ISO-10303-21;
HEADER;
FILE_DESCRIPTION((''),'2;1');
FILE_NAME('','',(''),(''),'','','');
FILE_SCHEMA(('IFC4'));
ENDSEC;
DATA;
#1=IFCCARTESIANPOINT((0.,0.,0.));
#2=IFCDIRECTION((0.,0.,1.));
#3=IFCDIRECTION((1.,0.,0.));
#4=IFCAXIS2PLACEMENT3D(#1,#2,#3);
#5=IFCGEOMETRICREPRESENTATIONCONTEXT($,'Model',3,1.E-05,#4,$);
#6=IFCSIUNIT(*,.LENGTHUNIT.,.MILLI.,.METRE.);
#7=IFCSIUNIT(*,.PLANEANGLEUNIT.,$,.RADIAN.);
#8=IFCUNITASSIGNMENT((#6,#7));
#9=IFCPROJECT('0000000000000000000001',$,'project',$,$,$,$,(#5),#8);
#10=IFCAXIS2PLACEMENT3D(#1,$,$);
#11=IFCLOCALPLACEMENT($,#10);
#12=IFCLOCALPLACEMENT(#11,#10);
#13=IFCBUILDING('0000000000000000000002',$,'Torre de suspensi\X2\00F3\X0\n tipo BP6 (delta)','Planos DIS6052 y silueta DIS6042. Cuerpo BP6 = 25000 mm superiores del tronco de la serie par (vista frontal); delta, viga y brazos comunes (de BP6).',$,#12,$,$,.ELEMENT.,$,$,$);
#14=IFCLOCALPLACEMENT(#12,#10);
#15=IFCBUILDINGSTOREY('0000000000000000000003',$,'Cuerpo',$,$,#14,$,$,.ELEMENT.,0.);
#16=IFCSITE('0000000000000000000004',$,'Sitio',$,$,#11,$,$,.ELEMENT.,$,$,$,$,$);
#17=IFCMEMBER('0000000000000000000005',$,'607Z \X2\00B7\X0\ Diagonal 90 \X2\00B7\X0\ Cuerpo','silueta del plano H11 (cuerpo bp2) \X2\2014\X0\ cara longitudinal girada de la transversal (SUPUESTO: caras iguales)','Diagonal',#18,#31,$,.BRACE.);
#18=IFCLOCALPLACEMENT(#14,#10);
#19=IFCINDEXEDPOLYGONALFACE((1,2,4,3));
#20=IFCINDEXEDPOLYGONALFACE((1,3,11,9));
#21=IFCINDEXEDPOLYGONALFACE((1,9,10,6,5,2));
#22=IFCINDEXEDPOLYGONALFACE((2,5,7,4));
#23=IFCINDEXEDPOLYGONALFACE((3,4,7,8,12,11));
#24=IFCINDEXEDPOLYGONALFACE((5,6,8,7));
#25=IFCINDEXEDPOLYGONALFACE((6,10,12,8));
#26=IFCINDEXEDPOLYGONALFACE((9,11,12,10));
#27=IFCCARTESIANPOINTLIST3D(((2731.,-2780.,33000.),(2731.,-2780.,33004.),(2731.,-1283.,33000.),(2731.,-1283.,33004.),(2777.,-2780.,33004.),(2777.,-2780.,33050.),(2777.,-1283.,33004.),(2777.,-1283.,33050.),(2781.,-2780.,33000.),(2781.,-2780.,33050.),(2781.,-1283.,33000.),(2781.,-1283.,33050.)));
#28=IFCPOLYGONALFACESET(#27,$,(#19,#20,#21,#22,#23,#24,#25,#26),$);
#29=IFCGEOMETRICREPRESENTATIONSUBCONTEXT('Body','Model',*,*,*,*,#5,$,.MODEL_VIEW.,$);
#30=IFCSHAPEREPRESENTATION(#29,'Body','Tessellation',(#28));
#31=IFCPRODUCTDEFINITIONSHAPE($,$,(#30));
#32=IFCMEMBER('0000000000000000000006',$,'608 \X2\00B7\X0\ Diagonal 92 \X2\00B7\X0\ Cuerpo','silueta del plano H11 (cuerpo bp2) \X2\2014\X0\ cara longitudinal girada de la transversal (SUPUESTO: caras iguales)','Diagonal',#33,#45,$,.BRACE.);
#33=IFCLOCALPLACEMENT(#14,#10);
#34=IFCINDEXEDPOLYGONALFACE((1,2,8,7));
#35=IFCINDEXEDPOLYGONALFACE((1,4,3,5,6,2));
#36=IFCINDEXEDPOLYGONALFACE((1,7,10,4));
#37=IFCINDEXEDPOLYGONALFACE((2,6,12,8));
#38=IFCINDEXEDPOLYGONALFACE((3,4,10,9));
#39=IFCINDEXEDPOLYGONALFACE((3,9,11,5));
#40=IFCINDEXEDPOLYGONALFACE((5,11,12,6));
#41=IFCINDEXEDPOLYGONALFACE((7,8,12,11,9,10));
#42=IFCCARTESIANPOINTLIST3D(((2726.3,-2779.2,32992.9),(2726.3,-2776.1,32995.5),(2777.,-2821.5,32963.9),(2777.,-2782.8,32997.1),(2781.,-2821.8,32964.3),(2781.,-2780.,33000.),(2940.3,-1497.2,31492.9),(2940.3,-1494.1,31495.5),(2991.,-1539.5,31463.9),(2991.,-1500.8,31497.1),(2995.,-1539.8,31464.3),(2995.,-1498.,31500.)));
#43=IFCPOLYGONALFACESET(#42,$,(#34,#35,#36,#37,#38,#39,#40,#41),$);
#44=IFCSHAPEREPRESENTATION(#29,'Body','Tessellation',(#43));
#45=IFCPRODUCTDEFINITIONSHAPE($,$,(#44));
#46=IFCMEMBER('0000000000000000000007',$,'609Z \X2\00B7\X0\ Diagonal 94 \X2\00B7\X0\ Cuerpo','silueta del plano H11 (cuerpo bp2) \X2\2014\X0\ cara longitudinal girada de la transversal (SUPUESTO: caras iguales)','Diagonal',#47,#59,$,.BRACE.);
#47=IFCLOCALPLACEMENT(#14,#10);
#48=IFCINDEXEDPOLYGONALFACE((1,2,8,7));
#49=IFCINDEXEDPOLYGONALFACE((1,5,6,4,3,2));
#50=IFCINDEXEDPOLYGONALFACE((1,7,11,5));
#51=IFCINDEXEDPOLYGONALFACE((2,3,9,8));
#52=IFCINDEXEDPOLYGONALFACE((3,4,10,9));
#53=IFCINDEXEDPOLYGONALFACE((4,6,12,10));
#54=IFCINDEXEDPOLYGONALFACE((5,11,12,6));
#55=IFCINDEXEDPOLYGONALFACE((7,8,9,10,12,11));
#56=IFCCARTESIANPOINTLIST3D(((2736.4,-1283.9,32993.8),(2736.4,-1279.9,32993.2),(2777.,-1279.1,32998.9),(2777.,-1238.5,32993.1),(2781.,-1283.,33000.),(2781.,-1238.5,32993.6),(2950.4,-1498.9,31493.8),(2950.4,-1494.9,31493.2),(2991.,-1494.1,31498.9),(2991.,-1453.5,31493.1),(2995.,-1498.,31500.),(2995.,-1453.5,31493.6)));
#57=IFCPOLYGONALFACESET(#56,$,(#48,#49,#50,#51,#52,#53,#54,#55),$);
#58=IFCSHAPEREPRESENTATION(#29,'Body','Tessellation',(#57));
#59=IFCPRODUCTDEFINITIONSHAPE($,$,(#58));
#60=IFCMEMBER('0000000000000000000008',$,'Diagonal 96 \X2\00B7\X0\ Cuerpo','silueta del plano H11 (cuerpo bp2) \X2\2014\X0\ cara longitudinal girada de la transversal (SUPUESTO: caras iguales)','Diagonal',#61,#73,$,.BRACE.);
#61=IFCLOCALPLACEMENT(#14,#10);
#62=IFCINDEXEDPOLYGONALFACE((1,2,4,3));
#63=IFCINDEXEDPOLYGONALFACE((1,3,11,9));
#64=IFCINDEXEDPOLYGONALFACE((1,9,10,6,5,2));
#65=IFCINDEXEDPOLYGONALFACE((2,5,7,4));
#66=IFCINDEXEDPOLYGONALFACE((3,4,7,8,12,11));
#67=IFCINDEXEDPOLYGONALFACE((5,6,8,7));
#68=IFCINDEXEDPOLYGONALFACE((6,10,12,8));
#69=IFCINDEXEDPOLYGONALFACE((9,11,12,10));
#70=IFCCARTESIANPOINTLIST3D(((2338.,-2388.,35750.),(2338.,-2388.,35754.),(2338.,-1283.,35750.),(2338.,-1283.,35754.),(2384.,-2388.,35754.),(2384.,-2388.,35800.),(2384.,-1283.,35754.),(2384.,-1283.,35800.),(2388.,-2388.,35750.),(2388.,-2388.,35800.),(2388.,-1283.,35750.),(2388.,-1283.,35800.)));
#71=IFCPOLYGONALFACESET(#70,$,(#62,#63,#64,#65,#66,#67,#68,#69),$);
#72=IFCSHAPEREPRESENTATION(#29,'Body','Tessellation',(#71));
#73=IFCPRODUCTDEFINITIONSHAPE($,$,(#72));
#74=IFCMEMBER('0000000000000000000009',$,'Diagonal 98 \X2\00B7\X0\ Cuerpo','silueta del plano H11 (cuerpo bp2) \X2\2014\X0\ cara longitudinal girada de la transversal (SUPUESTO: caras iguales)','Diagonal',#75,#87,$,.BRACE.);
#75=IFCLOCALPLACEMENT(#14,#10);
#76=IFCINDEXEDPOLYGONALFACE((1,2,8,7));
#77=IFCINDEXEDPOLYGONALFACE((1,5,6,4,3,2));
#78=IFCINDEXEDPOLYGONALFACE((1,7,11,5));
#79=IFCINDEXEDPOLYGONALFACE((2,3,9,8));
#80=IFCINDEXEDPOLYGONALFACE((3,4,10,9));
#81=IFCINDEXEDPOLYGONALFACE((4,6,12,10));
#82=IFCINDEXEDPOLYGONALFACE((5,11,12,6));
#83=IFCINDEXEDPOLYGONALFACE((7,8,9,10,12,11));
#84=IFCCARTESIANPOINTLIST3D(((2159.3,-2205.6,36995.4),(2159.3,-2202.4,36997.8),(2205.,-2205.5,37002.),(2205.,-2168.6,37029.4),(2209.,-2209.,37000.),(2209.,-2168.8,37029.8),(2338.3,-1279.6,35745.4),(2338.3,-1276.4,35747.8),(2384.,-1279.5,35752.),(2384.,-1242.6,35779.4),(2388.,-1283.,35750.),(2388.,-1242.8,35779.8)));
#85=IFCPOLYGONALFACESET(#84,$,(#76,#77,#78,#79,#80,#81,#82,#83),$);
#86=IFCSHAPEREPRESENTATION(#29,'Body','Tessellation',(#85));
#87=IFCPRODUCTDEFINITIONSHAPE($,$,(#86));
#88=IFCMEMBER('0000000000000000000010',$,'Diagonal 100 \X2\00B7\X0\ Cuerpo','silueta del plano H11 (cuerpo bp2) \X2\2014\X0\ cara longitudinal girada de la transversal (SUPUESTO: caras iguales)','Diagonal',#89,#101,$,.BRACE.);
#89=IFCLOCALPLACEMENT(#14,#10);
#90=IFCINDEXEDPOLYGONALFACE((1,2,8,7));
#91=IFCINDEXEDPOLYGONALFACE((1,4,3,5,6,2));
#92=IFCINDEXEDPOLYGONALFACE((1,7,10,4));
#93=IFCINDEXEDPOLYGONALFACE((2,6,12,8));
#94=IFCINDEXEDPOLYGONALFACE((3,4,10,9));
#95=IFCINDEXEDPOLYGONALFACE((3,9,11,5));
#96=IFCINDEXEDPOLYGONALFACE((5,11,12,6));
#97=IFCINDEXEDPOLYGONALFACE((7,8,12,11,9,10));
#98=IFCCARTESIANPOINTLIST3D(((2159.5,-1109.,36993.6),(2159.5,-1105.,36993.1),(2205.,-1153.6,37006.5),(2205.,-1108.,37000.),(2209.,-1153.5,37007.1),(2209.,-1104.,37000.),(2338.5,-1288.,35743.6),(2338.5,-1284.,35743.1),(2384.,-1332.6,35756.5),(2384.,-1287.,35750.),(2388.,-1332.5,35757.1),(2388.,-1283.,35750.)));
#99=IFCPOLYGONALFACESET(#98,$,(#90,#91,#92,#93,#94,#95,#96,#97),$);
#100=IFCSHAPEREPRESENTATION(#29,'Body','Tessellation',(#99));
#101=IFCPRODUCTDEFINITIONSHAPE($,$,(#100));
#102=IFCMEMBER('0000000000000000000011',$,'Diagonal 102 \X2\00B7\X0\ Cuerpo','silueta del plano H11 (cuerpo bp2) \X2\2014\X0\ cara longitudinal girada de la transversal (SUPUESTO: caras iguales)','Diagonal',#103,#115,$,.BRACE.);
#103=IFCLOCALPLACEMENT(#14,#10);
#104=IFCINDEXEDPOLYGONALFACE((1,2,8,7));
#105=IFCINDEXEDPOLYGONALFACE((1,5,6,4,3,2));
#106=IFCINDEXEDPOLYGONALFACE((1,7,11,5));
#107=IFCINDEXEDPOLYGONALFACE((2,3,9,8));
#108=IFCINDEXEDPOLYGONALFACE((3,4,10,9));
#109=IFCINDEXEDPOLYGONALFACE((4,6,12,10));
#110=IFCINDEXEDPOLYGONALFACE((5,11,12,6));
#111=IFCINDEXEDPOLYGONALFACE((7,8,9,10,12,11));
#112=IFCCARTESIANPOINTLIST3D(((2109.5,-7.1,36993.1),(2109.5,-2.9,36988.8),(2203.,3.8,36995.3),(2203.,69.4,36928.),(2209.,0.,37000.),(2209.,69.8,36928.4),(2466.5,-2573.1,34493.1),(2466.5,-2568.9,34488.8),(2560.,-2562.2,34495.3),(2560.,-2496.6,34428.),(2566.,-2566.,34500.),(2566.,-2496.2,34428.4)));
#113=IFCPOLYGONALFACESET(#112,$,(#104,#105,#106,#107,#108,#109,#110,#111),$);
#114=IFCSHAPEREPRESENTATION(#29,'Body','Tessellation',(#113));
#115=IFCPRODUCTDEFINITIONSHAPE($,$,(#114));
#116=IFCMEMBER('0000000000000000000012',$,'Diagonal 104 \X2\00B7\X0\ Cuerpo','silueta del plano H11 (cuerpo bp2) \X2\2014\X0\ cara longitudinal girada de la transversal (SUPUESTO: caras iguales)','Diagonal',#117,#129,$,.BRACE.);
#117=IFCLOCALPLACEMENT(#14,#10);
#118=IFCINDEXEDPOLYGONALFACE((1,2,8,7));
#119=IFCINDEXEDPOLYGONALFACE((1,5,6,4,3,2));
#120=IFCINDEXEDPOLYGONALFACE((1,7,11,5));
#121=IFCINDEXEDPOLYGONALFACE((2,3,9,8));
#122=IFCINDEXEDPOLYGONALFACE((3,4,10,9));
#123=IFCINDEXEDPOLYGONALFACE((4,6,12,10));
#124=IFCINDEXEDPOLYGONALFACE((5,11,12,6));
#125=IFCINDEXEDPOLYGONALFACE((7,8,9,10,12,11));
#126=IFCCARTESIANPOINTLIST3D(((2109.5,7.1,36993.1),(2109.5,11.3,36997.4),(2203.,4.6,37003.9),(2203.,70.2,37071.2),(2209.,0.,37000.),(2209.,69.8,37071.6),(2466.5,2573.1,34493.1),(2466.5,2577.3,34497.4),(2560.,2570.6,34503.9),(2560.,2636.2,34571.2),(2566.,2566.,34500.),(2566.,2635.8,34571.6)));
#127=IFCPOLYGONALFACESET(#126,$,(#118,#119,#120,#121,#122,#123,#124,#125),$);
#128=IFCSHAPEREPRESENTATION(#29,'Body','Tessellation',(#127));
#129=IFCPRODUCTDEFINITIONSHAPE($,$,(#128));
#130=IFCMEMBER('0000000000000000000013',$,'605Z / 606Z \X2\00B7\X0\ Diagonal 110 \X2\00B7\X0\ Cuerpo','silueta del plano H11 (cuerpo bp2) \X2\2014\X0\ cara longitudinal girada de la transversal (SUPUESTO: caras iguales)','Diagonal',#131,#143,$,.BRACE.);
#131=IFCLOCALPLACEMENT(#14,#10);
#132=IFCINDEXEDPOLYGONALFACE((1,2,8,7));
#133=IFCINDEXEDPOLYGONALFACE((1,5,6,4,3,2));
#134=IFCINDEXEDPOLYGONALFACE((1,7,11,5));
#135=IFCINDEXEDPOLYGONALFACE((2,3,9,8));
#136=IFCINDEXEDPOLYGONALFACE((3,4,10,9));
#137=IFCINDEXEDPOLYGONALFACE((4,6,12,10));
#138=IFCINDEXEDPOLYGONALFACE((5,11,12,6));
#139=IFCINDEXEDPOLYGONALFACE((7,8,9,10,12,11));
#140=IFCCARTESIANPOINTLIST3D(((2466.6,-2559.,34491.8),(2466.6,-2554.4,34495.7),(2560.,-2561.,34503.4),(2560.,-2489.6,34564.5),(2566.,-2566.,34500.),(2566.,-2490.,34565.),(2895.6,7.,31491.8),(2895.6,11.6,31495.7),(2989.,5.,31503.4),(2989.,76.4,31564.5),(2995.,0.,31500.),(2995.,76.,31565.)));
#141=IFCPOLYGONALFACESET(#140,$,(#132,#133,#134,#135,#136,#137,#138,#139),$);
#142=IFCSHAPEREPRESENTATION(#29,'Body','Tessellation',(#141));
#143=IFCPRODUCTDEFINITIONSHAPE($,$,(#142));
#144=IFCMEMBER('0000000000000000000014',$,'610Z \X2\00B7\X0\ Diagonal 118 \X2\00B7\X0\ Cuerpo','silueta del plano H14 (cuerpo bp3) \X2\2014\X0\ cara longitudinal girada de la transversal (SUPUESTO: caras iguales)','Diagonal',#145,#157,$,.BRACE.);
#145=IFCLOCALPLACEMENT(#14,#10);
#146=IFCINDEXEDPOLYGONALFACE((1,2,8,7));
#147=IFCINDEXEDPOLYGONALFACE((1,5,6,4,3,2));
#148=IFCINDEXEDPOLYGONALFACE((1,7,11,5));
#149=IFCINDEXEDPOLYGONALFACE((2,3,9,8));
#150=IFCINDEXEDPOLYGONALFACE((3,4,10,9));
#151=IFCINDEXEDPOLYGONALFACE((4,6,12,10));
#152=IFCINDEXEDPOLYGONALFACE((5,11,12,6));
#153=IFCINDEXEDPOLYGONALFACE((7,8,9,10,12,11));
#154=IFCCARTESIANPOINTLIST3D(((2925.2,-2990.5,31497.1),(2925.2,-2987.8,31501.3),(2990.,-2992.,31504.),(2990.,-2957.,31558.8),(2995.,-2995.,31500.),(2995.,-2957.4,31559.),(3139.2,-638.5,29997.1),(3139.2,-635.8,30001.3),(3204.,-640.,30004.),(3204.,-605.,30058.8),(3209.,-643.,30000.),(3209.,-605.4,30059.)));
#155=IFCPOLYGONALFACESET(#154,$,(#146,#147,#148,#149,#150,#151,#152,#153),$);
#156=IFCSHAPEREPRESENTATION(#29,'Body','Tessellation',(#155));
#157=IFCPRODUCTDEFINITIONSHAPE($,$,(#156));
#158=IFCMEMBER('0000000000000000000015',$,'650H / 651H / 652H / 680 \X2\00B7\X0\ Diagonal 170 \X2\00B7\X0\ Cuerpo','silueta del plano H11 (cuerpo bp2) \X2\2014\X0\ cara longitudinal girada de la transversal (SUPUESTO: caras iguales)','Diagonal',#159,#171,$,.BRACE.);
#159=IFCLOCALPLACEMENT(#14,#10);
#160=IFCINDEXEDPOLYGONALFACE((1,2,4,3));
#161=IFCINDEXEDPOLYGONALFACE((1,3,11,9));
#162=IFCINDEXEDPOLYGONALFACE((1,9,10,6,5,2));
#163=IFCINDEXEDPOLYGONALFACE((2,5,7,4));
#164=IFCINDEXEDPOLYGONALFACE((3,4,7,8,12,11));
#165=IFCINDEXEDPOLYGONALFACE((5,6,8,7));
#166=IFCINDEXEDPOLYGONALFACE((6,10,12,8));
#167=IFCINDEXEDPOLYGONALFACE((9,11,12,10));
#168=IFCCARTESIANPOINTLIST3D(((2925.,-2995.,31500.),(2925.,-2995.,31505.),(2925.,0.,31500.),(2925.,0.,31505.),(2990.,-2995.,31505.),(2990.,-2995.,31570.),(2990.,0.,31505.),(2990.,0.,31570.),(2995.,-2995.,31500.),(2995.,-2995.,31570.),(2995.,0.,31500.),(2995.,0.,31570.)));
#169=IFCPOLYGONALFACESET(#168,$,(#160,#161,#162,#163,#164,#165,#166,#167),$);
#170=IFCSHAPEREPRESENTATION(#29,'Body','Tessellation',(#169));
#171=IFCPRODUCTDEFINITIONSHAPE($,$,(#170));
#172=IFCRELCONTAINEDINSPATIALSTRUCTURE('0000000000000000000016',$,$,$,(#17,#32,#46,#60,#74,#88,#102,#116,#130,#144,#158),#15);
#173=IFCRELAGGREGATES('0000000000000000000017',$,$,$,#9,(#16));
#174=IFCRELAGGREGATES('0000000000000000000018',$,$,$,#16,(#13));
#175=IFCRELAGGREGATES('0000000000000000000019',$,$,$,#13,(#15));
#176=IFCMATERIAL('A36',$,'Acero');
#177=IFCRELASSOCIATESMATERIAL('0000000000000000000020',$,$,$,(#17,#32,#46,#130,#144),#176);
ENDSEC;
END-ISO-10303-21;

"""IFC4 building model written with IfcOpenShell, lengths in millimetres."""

from ifc_helpers import new_model, si_unit, frame, frame_2d, origin, origin_with_axes, place, context, subcontext, project, spatial, l_section, extrude, material, element, save


model = new_model("IFC4")

# Units and contexts
model_context = context("Model", 3, precision=1e-05, world=origin_with_axes())
body_context = subcontext(model_context, "Body", "Model", "MODEL_VIEW")
ifc_project = project(units=[si_unit("LENGTHUNIT", "METRE", prefix="MILLI"), si_unit("PLANEANGLEUNIT", "RADIAN")], contexts=[model_context])

# Site, building, storey
site_placement = place(None, origin())
site = spatial("IfcSite", under=ifc_project, at=site_placement, Name="Sitio", CompositionType="ELEMENT")
building_placement = place(site_placement, origin())
building = spatial("IfcBuilding", under=site, at=building_placement, Name="Torre de suspensión tipo BP6 (delta)", Description="Planos DIS6052 y silueta DIS6042. Cuerpo BP6 = 25000 mm superiores del tronco de la serie par (vista frontal); delta, viga y brazos comunes (de BP6).", CompositionType="ELEMENT")
storey_placement = place(building_placement, origin())
storey = spatial("IfcBuildingStorey", under=building, at=storey_placement, Name="Cuerpo", CompositionType="ELEMENT", Elevation=0.0)

# Members
ifc_material_1 = material(Name="A36", Category="Acero")
member_1_placement = place(storey_placement, frame((2781.0, -2780.0, 33000.0), z_axis=(0.0, 1.0, 0.0), x_axis=(-1.0, 0.0, 0.0)))
element("IfcMember", 1, at=member_1_placement, inside=storey, material=ifc_material_1, Name="607Z · Diagonal 90 · Cuerpo", Description="silueta del plano H11 (cuerpo bp2) — cara longitudinal girada de la transversal (SUPUESTO: caras iguales)", ObjectType="Diagonal", PredefinedType="BRACE", context=body_context, shape_type="SweptSolid", body=[
    extrude(l_section(Depth=50.0, Width=50.0, Thickness=4.0, at=frame_2d((25.0, 25.0))), None, (0.0, 0.0, 1.0), 1497.0),
])
member_2_placement = place(storey_placement, frame((2995.0, -1498.0, 31500.0), z_axis=(-0.107821, -0.645918, 0.755754), x_axis=(-0.99417, 0.070052, -0.081964)))
element("IfcMember", 2, at=member_2_placement, inside=storey, material=ifc_material_1, Name="608 · Diagonal 92 · Cuerpo", Description="silueta del plano H11 (cuerpo bp2) — cara longitudinal girada de la transversal (SUPUESTO: caras iguales)", ObjectType="Diagonal", PredefinedType="BRACE", context=body_context, shape_type="SweptSolid", body=[
    extrude(l_section(Depth=55.0, Width=55.0, Thickness=4.0, at=frame_2d((27.5, 27.5))), None, (0.0, 0.0, 1.0), 1984.8),
])
member_3_placement = place(storey_placement, frame((2781.0, -1283.0, 33000.0), z_axis=(0.139836, -0.140489, -0.980157), x_axis=(-0.990175, -0.01984, -0.138421)))
element("IfcMember", 3, at=member_3_placement, inside=storey, material=ifc_material_1, Name="609Z · Diagonal 94 · Cuerpo", Description="silueta del plano H11 (cuerpo bp2) — cara longitudinal girada de la transversal (SUPUESTO: caras iguales)", ObjectType="Diagonal", PredefinedType="BRACE", context=body_context, shape_type="SweptSolid", body=[
    extrude(l_section(Depth=45.0, Width=45.0, Thickness=4.0, at=frame_2d((22.5, 22.5))), None, (0.0, 0.0, 1.0), 1530.4),
])
member_4_placement = place(storey_placement, frame((2388.0, -2388.0, 35750.0), z_axis=(0.0, 1.0, 0.0), x_axis=(-1.0, 0.0, 0.0)))
element("IfcMember", 4, at=member_4_placement, inside=storey, Name="Diagonal 96 · Cuerpo", Description="silueta del plano H11 (cuerpo bp2) — cara longitudinal girada de la transversal (SUPUESTO: caras iguales)", ObjectType="Diagonal", PredefinedType="BRACE", context=body_context, shape_type="SweptSolid", body=[
    extrude(l_section(Depth=50.0, Width=50.0, Thickness=4.0, at=frame_2d((25.0, 25.0))), None, (0.0, 0.0, 1.0), 1105.0),
])
member_5_placement = place(storey_placement, frame((2209.0, -2209.0, 37000.0), z_axis=(0.114312, 0.591356, -0.798267), x_axis=(-0.993445, 0.068045, -0.091854)))
element("IfcMember", 5, at=member_5_placement, inside=storey, Name="Diagonal 98 · Cuerpo", Description="silueta del plano H11 (cuerpo bp2) — cara longitudinal girada de la transversal (SUPUESTO: caras iguales)", ObjectType="Diagonal", PredefinedType="BRACE", context=body_context, shape_type="SweptSolid", body=[
    extrude(l_section(Depth=50.0, Width=50.0, Thickness=4.0, at=frame_2d((25.0, 25.0))), None, (0.0, 0.0, 1.0), 1565.9),
])
member_6_placement = place(storey_placement, frame((2388.0, -1283.0, 35750.0), z_axis=(-0.140351, 0.140351, 0.980104), x_axis=(-0.990102, -0.019895, -0.138934)))
element("IfcMember", 6, at=member_6_placement, inside=storey, Name="Diagonal 100 · Cuerpo", Description="silueta del plano H11 (cuerpo bp2) — cara longitudinal girada de la transversal (SUPUESTO: caras iguales)", ObjectType="Diagonal", PredefinedType="BRACE", context=body_context, shape_type="SweptSolid", body=[
    extrude(l_section(Depth=50.0, Width=50.0, Thickness=4.0, at=frame_2d((25.0, 25.0))), None, (0.0, 0.0, 1.0), 1275.4),
])
for number, where, z_axis, x_axis, name in (
    (7, (2209.0, 0.0, 37000.0), (0.09916, -0.712728, -0.694396), (-0.995072, -0.071024, -0.069197), "Diagonal 102 · Cuerpo"),
    (8, (2209.0, 0.0, 37000.0), (0.09916, 0.712728, -0.694396), (-0.995072, 0.071024, -0.069197), "Diagonal 104 · Cuerpo"),
):
    element("IfcMember", number, at=place(storey_placement, frame(where, z_axis=z_axis, x_axis=x_axis)), inside=storey, Name=name, Description="silueta del plano H11 (cuerpo bp2) — cara longitudinal girada de la transversal (SUPUESTO: caras iguales)", ObjectType="Diagonal", PredefinedType="BRACE", context=body_context, shape_type="SweptSolid", body=[
        extrude(l_section(Depth=100.0, Width=100.0, Thickness=6.0, at=frame_2d((50.0, 50.0))), None, (0.0, 0.0, 1.0), 3600.3),
    ])
member_7_placement = place(storey_placement, frame((2566.0, -2566.0, 34500.0), z_axis=(0.108035, 0.646194, -0.755488), x_axis=(-0.994147, 0.070222, -0.082099)))
element("IfcMember", 9, at=member_7_placement, inside=storey, material=ifc_material_1, Name="605Z / 606Z · Diagonal 110 · Cuerpo", Description="silueta del plano H11 (cuerpo bp2) — cara longitudinal girada de la transversal (SUPUESTO: caras iguales)", ObjectType="Diagonal", PredefinedType="BRACE", context=body_context, shape_type="SweptSolid", body=[
    extrude(l_section(Depth=100.0, Width=100.0, Thickness=6.0, at=frame_2d((50.0, 50.0))), None, (0.0, 0.0, 1.0), 3970.9),
])
member_8_placement = place(storey_placement, frame((2995.0, -2995.0, 31500.0), z_axis=(0.076489, 0.84066, -0.536135), x_axis=(-0.99707, 0.06449, -0.041129)))
element("IfcMember", 10, at=member_8_placement, inside=storey, material=ifc_material_1, Name="610Z · Diagonal 118 · Cuerpo", Description="silueta del plano H14 (cuerpo bp3) — cara longitudinal girada de la transversal (SUPUESTO: caras iguales)", ObjectType="Diagonal", PredefinedType="BRACE", context=body_context, shape_type="SweptSolid", body=[
    extrude(l_section(Depth=70.0, Width=70.0, Thickness=5.0, at=frame_2d((35.0, 35.0))), None, (0.0, 0.0, 1.0), 2797.8),
])
member_9_placement = place(storey_placement, frame((2995.0, -2995.0, 31500.0), z_axis=(0.0, 1.0, 0.0), x_axis=(-1.0, 0.0, 0.0)))
element("IfcMember", 11, at=member_9_placement, inside=storey, Name="650H / 651H / 652H / 680 · Diagonal 170 · Cuerpo", Description="silueta del plano H11 (cuerpo bp2) — cara longitudinal girada de la transversal (SUPUESTO: caras iguales)", ObjectType="Diagonal", PredefinedType="BRACE", context=body_context, shape_type="SweptSolid", body=[
    extrude(l_section(Depth=70.0, Width=70.0, Thickness=5.0, at=frame_2d((35.0, 35.0))), None, (0.0, 0.0, 1.0), 2995.0),
])

save(model, "model.ifc")
